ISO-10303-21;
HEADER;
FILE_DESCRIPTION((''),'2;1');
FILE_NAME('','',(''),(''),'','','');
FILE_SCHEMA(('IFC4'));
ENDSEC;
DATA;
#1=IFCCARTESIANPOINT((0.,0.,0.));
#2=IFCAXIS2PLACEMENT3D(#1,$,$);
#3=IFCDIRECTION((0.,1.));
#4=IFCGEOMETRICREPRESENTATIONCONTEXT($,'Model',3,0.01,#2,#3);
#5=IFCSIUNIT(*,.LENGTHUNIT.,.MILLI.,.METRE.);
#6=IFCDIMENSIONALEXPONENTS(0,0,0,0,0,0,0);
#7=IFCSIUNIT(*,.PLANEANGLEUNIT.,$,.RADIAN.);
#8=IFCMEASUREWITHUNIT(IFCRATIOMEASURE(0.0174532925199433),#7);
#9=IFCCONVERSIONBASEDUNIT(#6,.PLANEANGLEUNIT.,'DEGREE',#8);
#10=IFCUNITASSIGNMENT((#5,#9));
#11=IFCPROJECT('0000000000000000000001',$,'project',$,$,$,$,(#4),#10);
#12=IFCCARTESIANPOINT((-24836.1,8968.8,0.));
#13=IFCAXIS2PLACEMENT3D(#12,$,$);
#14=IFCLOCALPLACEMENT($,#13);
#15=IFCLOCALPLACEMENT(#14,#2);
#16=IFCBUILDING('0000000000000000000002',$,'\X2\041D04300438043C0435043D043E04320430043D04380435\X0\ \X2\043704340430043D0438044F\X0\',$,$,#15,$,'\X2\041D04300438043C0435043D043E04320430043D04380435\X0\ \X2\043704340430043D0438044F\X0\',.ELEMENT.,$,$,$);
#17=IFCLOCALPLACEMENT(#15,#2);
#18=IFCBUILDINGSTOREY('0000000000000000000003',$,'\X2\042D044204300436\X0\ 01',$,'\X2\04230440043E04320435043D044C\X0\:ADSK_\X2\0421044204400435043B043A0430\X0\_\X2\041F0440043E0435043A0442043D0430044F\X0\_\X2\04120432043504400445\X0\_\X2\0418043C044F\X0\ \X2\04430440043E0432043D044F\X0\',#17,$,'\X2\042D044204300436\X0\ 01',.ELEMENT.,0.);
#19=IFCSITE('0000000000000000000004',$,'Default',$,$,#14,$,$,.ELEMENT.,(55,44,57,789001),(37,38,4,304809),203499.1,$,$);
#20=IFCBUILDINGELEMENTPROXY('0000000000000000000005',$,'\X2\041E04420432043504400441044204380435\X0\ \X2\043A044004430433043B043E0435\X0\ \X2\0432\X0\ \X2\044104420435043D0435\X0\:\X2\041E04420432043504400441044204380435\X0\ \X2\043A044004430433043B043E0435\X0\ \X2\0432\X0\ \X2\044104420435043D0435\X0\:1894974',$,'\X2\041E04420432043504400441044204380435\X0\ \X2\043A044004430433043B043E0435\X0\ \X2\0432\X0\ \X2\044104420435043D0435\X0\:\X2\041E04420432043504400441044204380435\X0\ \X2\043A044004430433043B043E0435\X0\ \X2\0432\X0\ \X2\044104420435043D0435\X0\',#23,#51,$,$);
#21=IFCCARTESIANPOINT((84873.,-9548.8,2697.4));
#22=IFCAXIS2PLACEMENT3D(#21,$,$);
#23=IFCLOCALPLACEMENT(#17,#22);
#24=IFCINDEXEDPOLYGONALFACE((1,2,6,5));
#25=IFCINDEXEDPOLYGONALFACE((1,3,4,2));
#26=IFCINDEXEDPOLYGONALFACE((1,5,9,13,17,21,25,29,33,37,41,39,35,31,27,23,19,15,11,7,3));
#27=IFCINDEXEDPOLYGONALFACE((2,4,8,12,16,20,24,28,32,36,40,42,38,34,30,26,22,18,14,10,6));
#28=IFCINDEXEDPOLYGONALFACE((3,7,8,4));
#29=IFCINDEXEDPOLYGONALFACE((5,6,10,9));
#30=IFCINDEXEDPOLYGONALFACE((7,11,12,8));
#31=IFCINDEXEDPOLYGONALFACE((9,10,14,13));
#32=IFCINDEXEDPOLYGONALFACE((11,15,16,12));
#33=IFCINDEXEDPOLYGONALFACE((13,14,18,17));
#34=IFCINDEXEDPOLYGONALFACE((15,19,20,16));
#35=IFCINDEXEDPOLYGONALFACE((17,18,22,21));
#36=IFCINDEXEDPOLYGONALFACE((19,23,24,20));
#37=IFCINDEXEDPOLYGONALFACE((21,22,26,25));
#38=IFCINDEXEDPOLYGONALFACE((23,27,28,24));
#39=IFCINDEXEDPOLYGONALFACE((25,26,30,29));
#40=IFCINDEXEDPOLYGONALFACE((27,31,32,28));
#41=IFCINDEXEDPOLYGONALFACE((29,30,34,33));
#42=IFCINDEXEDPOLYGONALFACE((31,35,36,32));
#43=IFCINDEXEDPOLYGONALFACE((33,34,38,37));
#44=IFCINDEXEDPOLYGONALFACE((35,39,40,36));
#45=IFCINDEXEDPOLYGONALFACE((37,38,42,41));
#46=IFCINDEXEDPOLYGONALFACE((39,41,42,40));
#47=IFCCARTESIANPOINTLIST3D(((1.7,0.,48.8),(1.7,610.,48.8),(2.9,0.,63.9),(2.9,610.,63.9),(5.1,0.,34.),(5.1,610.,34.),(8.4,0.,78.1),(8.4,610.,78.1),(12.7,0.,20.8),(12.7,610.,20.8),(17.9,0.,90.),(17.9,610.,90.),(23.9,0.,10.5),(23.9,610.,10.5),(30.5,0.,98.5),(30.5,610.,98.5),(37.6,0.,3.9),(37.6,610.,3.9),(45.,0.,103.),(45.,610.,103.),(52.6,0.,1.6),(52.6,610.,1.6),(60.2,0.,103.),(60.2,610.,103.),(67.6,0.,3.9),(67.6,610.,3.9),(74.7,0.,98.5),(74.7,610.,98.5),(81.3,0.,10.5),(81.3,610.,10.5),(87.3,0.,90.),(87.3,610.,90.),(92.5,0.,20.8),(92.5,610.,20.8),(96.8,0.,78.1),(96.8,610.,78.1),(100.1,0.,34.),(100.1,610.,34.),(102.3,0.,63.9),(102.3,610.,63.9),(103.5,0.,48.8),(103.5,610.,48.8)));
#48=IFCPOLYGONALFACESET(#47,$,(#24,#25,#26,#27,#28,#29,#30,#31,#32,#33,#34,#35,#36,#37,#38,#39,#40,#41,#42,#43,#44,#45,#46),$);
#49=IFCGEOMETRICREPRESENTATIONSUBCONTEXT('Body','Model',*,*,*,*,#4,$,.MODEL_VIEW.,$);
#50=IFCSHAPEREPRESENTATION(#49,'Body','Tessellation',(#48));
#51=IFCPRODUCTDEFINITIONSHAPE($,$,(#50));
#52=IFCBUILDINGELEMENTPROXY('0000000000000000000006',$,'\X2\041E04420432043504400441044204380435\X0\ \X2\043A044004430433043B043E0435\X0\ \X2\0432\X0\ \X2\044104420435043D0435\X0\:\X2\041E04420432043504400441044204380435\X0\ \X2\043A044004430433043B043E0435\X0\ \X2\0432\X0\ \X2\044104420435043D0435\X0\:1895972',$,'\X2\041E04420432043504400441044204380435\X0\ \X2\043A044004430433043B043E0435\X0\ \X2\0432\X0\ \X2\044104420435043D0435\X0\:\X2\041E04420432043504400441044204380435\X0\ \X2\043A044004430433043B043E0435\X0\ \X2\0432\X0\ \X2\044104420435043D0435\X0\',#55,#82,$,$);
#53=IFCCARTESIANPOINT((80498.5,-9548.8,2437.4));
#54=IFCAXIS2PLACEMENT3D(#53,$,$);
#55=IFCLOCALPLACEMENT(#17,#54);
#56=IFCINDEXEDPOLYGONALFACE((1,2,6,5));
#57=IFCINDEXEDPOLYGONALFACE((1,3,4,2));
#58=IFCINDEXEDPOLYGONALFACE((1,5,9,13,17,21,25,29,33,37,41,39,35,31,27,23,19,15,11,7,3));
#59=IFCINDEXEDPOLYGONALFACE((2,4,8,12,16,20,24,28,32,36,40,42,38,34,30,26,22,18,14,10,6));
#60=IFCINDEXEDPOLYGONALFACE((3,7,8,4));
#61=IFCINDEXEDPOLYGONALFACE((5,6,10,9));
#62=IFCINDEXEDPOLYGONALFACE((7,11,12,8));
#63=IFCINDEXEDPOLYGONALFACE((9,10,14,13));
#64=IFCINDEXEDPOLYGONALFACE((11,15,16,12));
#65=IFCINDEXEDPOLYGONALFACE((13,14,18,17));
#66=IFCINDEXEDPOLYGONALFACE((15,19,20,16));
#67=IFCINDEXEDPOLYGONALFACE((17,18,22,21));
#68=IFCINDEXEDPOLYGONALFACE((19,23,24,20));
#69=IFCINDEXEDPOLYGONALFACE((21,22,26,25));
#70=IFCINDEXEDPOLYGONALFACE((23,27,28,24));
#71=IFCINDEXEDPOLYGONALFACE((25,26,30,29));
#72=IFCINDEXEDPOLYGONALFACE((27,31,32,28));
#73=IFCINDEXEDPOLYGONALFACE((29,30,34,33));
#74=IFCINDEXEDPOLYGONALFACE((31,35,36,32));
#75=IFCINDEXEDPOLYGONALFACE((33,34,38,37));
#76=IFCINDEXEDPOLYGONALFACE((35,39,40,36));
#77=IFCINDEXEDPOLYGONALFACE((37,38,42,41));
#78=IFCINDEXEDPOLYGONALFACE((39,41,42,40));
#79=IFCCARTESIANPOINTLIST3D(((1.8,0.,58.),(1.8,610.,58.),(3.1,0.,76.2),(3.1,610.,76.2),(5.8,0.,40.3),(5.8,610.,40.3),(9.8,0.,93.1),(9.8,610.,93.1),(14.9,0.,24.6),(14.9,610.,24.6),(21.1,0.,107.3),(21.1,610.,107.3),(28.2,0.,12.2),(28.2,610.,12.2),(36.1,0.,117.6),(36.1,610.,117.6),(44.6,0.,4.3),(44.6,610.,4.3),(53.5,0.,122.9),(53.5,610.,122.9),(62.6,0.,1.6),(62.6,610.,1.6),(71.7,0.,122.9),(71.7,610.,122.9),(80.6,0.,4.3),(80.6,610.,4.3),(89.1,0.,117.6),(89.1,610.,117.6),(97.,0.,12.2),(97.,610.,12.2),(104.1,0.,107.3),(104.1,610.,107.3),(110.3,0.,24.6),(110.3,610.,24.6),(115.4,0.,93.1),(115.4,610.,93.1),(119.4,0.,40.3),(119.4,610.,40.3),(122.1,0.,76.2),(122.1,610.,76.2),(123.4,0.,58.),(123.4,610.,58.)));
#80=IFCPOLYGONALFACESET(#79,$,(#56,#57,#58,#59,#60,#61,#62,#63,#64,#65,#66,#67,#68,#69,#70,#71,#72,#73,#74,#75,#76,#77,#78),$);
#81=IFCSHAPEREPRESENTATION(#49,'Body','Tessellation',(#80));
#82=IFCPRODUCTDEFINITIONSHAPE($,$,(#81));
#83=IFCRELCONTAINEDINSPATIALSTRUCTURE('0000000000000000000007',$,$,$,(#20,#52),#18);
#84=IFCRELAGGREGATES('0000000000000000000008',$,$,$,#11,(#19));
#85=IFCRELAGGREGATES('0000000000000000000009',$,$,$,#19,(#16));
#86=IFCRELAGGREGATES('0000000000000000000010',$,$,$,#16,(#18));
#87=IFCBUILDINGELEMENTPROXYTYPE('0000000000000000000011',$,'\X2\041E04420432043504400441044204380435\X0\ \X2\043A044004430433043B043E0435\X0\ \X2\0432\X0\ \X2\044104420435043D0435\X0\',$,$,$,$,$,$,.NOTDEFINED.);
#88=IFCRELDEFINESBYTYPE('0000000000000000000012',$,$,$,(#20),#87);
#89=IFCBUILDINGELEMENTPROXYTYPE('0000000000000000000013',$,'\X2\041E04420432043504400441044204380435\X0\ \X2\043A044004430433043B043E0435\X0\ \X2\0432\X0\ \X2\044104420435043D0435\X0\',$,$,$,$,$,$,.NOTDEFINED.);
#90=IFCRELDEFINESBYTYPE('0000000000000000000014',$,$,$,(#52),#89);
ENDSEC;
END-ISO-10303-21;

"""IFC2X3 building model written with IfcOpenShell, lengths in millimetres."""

from ifc_helpers import new_model, entity, si_unit, converted_unit, direction, frame, origin, origin_2d_with_axis, place, context, subcontext, project, spatial, circle, extrude, type_object, element, save


model = new_model("IFC2X3")

# Units and contexts
model_context = context("Model", 3, precision=0.01, world=origin(), true_north=direction((0.0, 1.0)))
body_context = subcontext(model_context, "Body", "Model", "MODEL_VIEW")
ifc_project = project(units=[si_unit("LENGTHUNIT", "METRE", prefix="MILLI"), converted_unit("PLANEANGLEUNIT", "DEGREE", entity("IfcRatioMeasure", 0.0174532925199433), si_unit("PLANEANGLEUNIT", "RADIAN"), dimensions=[0, 0, 0, 0, 0, 0, 0])], contexts=[model_context])

# Site, building, storey
site_placement = place(None, frame((-24836.1, 8968.8, 0.0)))
site = spatial("IfcSite", under=ifc_project, at=site_placement, Name="Default", CompositionType="ELEMENT", RefLatitude=(55, 44, 57, 789001), RefLongitude=(37, 38, 4, 304809), RefElevation=203499.1)
building_placement = place(site_placement, origin())
building = spatial("IfcBuilding", under=site, at=building_placement, Name="Наименование здания", LongName="Наименование здания", CompositionType="ELEMENT")
storey_placement = place(building_placement, origin())
storey = spatial("IfcBuildingStorey", under=building, at=storey_placement, Name="Этаж 01", ObjectType="Уровень:ADSK_Стрелка_Проектная_Вверх_Имя уровня", LongName="Этаж 01", CompositionType="ELEMENT", Elevation=0.0)

# Building element proxies
building_element_proxy_type_1 = type_object("IfcBuildingElementProxyType", Name="Отверстие круглое в стене", PredefinedType="NOTDEFINED")
proxy_1_placement = place(storey_placement, frame((84873.0, -9548.8, 2697.4)))
element("IfcBuildingElementProxy", 1, at=proxy_1_placement, inside=storey, type_object=building_element_proxy_type_1, Name="Отверстие круглое в стене:Отверстие круглое в стене:1894974", ObjectType="Отверстие круглое в стене:Отверстие круглое в стене", context=body_context, shape_type="SweptSolid", body=[
    extrude(circle(Radius=51.0, at=origin_2d_with_axis()), frame((52.6, 0.0, 52.6), z_axis=(0.0, 1.0, 0.0), x_axis=(0.0, 0.0, -1.0)), (0.0, 0.0, 1.0), 610.0),
])
building_element_proxy_type_2 = type_object("IfcBuildingElementProxyType", Name="Отверстие круглое в стене", PredefinedType="NOTDEFINED")
proxy_2_placement = place(storey_placement, frame((80498.5, -9548.8, 2437.4)))
element("IfcBuildingElementProxy", 2, at=proxy_2_placement, inside=storey, type_object=building_element_proxy_type_2, Name="Отверстие круглое в стене:Отверстие круглое в стене:1895972", ObjectType="Отверстие круглое в стене:Отверстие круглое в стене", context=body_context, shape_type="SweptSolid", body=[
    extrude(circle(Radius=61.0, at=origin_2d_with_axis()), frame((62.6, 0.0, 62.6), z_axis=(0.0, 1.0, 0.0), x_axis=(0.0, 0.0, -1.0)), (0.0, 0.0, 1.0), 610.0),
])

save(model, "model.ifc")
